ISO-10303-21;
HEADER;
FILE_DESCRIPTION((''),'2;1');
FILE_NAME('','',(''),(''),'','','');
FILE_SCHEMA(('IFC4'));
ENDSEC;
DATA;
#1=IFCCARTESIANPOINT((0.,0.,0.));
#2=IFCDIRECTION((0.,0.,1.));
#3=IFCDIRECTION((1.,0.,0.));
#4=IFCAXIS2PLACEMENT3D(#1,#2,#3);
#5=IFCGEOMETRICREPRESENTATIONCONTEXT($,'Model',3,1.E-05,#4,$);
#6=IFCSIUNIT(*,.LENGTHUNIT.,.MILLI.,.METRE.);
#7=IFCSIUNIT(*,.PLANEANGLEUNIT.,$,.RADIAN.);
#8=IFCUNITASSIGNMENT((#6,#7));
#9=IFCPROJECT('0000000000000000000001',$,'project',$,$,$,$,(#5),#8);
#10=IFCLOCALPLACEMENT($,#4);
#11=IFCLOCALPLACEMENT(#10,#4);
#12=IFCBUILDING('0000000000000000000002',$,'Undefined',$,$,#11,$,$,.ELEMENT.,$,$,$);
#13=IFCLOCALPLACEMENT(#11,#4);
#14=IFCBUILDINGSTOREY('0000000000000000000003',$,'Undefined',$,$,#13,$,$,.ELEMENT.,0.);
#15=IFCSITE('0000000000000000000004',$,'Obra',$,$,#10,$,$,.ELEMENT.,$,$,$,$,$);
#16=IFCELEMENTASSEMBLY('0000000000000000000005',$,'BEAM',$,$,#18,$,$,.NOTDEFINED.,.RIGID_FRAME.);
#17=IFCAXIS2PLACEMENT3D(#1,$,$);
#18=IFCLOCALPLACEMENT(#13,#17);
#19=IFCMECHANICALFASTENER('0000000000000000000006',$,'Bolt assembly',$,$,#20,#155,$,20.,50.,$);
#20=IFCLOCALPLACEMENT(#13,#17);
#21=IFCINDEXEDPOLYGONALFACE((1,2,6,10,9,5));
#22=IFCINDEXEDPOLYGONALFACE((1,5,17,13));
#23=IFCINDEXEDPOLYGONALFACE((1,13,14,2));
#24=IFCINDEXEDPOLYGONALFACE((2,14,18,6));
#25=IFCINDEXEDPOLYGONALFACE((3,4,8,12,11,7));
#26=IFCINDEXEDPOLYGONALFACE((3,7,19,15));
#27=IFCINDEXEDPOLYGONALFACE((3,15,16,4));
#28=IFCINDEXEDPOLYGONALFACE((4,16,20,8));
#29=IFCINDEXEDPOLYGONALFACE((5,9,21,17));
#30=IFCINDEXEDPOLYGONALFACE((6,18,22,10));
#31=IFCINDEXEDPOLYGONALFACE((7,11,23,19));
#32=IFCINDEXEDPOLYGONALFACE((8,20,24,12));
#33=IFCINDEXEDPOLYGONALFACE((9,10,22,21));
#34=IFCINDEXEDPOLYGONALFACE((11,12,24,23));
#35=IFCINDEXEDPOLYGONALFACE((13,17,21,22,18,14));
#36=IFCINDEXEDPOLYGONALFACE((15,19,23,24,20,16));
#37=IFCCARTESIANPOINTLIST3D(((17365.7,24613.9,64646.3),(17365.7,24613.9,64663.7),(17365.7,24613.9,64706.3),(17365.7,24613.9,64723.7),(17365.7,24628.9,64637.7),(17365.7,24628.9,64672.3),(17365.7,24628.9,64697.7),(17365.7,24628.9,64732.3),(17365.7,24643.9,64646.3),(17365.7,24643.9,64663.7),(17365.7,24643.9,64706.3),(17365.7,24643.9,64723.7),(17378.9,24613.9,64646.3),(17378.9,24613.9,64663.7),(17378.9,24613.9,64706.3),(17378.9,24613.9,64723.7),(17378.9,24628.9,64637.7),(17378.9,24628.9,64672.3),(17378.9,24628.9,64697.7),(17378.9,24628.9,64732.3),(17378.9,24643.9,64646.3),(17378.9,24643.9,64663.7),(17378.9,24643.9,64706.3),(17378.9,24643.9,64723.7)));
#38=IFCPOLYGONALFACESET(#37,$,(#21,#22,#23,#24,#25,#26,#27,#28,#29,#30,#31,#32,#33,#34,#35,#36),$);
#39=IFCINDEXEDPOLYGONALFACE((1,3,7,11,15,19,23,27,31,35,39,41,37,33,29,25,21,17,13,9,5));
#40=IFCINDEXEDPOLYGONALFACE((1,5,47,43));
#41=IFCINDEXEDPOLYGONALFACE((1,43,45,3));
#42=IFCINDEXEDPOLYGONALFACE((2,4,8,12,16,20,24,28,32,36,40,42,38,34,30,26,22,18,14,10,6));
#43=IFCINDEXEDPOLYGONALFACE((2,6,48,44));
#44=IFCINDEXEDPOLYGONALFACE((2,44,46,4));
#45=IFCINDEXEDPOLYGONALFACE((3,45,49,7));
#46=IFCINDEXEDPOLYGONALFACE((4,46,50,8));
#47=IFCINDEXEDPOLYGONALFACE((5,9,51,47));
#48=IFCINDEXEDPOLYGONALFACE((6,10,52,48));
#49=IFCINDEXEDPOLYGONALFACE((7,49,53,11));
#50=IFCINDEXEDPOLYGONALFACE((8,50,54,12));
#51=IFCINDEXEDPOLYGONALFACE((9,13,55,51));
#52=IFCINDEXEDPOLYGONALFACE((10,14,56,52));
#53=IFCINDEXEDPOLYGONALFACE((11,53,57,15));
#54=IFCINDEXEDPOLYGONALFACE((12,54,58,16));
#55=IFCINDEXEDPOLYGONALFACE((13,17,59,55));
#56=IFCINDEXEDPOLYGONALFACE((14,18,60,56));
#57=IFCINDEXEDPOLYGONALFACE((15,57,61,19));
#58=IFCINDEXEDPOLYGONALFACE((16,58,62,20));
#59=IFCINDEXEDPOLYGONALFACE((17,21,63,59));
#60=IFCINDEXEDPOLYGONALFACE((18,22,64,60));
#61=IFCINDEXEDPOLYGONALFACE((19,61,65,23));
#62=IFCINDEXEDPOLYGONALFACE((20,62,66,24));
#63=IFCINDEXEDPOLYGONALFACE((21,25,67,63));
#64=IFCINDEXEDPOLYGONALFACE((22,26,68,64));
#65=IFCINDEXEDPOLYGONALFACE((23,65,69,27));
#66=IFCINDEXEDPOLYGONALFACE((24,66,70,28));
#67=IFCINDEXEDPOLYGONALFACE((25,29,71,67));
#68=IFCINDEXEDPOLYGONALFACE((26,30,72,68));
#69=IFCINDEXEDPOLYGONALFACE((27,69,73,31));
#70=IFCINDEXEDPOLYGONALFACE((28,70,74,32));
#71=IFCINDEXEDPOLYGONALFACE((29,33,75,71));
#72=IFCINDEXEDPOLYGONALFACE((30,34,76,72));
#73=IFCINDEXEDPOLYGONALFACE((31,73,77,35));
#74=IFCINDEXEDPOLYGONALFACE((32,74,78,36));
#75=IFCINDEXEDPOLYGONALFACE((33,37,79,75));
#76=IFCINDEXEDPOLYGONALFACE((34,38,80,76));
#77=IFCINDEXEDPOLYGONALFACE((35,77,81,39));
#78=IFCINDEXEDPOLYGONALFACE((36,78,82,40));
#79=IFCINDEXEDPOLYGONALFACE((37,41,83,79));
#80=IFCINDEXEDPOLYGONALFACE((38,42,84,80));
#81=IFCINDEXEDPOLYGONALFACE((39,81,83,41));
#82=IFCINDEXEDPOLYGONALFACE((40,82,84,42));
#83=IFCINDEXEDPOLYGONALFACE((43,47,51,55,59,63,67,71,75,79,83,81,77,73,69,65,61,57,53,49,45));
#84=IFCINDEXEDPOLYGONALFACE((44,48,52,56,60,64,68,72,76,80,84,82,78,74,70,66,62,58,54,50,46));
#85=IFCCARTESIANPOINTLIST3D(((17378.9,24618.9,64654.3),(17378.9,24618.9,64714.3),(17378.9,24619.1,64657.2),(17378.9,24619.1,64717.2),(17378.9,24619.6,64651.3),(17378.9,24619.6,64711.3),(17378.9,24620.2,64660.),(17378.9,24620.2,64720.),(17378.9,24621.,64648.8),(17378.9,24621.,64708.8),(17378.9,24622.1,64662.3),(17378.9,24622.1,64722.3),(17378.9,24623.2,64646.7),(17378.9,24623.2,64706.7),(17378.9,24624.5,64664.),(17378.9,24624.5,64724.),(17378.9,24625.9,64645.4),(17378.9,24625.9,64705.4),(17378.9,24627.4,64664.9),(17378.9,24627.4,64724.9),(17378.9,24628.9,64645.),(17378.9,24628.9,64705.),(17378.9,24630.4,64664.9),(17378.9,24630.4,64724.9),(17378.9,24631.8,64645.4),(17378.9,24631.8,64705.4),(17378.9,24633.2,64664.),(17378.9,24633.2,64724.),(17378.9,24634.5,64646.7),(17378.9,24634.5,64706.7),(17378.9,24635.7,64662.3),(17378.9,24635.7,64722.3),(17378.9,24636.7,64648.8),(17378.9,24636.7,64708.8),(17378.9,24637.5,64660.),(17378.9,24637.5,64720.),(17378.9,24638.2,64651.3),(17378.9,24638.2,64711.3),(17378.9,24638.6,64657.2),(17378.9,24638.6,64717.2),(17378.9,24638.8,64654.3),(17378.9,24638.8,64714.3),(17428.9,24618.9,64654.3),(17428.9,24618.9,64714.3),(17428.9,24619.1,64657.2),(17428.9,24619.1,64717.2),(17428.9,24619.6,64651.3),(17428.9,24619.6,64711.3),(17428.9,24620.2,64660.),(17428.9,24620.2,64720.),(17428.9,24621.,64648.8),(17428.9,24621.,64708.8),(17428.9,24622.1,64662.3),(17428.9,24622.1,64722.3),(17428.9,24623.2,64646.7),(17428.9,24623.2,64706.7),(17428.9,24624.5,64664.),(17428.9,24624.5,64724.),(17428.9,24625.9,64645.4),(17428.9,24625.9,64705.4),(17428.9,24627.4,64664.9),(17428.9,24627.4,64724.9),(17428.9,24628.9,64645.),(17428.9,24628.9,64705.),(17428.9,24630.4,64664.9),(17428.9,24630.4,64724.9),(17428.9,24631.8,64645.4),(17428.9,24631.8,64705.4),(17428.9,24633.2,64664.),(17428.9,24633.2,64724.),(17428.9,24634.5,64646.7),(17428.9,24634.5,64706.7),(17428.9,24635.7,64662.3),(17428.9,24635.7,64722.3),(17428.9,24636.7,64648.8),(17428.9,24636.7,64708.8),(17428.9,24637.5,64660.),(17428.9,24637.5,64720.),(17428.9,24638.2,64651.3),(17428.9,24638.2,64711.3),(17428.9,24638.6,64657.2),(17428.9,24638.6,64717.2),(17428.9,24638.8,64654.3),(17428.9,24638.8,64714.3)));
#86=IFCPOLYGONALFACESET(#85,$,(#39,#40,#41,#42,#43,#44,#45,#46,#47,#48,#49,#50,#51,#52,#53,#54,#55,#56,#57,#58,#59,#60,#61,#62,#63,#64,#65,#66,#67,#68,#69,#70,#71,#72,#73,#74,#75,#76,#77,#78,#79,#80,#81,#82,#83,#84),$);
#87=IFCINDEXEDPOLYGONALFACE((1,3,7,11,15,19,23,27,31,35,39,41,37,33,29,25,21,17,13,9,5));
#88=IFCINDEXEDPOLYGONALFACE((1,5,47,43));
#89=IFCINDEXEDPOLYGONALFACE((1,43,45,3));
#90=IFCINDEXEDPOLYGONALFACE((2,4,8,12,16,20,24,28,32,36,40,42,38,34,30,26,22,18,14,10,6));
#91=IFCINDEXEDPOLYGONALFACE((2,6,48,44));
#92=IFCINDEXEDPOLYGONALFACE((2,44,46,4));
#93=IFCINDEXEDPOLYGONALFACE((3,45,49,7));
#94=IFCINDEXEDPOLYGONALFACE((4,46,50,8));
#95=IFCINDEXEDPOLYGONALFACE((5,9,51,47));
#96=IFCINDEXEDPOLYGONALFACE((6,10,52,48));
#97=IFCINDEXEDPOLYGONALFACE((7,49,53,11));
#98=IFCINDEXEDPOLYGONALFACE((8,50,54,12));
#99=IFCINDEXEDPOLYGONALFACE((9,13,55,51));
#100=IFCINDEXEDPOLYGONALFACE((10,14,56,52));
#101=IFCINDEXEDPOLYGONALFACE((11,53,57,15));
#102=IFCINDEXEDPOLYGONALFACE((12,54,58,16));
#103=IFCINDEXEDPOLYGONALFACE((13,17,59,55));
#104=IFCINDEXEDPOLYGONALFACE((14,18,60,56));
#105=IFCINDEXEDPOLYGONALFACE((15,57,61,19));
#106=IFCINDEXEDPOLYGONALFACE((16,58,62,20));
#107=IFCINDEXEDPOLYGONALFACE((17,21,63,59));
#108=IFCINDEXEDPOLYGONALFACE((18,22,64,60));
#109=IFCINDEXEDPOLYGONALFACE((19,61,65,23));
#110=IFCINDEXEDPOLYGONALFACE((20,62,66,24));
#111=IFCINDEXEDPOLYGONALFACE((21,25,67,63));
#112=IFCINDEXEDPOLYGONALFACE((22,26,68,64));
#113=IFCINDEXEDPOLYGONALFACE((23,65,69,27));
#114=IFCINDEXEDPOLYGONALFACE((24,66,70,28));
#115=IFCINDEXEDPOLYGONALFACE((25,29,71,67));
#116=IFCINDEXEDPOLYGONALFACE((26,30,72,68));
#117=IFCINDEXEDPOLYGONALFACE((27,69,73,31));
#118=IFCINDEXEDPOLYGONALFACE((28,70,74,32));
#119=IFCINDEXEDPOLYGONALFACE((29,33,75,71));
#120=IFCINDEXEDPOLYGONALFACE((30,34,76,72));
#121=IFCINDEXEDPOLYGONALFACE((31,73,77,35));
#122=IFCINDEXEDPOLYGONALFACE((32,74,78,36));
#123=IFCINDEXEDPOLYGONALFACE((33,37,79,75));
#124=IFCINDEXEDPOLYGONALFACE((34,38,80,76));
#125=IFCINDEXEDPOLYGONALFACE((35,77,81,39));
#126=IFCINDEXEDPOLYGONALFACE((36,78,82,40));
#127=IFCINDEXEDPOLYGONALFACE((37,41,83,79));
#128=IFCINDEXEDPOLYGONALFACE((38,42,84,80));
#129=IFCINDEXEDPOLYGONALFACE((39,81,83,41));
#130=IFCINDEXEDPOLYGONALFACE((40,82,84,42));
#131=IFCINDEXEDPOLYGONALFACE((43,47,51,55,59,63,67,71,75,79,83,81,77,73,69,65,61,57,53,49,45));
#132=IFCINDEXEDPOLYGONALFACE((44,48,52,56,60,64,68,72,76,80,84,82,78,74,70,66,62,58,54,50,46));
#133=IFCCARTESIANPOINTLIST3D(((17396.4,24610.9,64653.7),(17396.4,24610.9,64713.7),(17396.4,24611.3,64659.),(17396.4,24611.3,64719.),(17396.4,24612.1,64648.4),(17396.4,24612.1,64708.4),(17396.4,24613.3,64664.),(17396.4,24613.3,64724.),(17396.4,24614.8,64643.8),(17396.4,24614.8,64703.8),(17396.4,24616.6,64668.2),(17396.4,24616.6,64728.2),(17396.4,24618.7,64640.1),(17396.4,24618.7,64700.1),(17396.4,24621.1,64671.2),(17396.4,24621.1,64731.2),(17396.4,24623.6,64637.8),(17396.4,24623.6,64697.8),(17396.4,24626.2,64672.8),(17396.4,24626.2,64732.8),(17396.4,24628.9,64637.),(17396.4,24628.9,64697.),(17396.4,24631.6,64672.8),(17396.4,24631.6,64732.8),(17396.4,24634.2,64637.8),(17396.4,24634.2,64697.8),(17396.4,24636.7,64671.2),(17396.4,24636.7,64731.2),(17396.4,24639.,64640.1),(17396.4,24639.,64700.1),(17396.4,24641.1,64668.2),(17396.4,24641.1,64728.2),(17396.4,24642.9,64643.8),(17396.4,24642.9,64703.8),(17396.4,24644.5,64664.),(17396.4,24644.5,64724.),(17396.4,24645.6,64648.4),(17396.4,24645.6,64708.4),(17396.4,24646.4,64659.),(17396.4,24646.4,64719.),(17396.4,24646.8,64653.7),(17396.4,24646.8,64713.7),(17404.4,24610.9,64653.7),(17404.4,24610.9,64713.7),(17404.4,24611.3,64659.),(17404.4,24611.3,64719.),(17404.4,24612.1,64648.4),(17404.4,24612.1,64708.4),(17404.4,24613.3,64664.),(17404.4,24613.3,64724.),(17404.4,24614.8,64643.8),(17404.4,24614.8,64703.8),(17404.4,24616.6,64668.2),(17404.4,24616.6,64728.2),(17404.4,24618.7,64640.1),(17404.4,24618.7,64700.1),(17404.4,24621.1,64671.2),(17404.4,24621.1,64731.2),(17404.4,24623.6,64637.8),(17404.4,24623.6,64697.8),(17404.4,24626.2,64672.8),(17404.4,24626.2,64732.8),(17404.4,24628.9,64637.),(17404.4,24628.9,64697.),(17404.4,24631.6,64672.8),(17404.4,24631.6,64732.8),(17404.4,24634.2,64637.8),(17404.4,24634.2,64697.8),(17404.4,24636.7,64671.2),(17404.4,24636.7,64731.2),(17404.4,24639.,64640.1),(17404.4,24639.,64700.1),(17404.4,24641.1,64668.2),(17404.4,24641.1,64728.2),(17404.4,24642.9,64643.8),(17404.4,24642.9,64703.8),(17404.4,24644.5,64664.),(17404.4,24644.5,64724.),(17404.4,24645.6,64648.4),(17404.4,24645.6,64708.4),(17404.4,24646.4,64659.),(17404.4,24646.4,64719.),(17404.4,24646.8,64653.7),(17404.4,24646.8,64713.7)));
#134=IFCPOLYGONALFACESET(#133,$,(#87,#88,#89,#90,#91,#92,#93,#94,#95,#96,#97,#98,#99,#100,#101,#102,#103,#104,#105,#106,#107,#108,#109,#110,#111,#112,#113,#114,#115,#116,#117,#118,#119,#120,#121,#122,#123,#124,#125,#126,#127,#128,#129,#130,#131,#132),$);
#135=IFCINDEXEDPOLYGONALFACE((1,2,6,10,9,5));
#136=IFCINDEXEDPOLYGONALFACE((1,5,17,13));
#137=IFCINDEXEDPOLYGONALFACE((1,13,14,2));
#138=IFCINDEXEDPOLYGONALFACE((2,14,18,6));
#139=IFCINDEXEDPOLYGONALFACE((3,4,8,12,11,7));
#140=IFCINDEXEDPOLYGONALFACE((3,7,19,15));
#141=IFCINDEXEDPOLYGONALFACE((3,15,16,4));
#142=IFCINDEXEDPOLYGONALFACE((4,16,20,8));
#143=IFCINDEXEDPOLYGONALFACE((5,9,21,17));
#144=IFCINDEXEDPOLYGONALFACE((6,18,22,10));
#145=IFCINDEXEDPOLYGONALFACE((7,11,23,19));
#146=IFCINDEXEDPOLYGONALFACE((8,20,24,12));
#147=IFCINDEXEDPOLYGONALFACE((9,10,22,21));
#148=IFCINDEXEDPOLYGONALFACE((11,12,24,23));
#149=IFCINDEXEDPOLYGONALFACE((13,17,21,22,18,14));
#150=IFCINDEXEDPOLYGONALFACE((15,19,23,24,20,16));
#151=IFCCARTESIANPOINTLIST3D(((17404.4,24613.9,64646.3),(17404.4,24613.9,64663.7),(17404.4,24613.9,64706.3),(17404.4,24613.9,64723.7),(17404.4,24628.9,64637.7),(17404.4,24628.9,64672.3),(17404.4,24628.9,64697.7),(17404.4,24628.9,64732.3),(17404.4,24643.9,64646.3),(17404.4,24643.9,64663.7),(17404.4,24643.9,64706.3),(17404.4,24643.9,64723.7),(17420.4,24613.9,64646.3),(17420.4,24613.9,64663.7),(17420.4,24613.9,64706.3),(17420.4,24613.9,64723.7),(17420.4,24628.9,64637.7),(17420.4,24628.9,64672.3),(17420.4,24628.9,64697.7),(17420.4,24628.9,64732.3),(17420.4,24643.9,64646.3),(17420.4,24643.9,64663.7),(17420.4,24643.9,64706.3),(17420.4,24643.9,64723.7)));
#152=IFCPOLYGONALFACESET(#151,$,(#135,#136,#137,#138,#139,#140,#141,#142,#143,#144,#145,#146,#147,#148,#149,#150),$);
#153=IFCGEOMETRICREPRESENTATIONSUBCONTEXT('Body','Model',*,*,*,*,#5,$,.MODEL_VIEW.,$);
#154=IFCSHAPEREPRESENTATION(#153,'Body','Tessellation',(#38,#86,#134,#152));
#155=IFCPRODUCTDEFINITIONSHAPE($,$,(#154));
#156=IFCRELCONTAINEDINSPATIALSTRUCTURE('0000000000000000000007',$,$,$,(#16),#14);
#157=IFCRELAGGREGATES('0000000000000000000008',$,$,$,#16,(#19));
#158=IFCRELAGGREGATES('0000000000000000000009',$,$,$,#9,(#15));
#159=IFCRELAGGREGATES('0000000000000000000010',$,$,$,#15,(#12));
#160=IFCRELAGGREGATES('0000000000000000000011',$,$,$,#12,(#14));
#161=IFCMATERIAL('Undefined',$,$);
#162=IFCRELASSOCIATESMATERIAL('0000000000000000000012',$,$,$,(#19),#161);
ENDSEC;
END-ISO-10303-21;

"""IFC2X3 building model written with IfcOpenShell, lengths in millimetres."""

from ifc_helpers import new_model, si_unit, frame, origin_with_axes, origin_2d_with_axis, place, context, subcontext, project, spatial, polyline, circle, outline, extrude, source, transform, mapped, material, element, aggregate, save


model = new_model("IFC2X3")

# Units and contexts
model_context = context("Model", 3, precision=1e-05, world=origin_with_axes())
body_context = subcontext(model_context, "Body", "Model", "MODEL_VIEW")
ifc_project = project(units=[si_unit("LENGTHUNIT", "METRE", prefix="MILLI"), si_unit("PLANEANGLEUNIT", "RADIAN")], contexts=[model_context])

# Site, building, storey
site_placement = place(None, origin_with_axes())
site = spatial("IfcSite", under=ifc_project, at=site_placement, Name="Obra", CompositionType="ELEMENT")
building_placement = place(site_placement, origin_with_axes())
building = spatial("IfcBuilding", under=site, at=building_placement, Name="Undefined", CompositionType="ELEMENT")
storey_placement = place(building_placement, origin_with_axes())
storey = spatial("IfcBuildingStorey", under=building, at=storey_placement, Name="Undefined", CompositionType="ELEMENT", Elevation=0.0)

# Shared definitions
ifc_material = material(Name="Undefined")

# Element assembly
shared_shape_1 = source(origin_with_axes(), body_context, "Body", "SweptSolid", [
    extrude(outline(polyline([(17.3, 0.0), (8.7, 15.0), (-8.7, 15.0), (-17.3, 0.0), (-8.7, -15.0), (8.7, -15.0), (17.3, 0.0)])), frame((0.0, -27.0, 0.0), z_axis=(0.0, 1.0, 0.0), x_axis=(1.0, 0.0, 0.0)), (0.0, 0.0, 1.0), 13.2),
    extrude(circle(Radius=10.0, at=origin_2d_with_axis()), frame((0.0, -13.8, 0.0), z_axis=(0.0, 1.0, 0.0), x_axis=(1.0, 0.0, 0.0)), (0.0, 0.0, 1.0), 50.0),
    extrude(circle(Radius=18.0, at=origin_2d_with_axis()), frame((0.0, 3.7, 0.0), z_axis=(0.0, 1.0, 0.0), x_axis=(1.0, 0.0, 0.0)), (0.0, 0.0, 1.0), 8.0),
    extrude(outline(polyline([(17.3, 0.0), (8.7, 15.0), (-8.7, 15.0), (-17.3, 0.0), (-8.7, -15.0), (8.7, -15.0), (17.3, 0.0)])), frame((0.0, 11.7, 0.0), z_axis=(0.0, 1.0, 0.0), x_axis=(1.0, 0.0, 0.0)), (0.0, 0.0, 1.0), 16.0),
])
assembly_1_placement = place(storey_placement, origin_with_axes())
assembly_1 = element("IfcElementAssembly", 1, at=assembly_1_placement, inside=storey, Name="BEAM", AssemblyPlace="NOTDEFINED", PredefinedType="RIGID_FRAME")

# Mechanical fastener
mechanical_fastener_1_placement = place(assembly_1_placement, frame((17392.7, 24668.9, 64850.0), z_axis=(0.000002, -1.0, 0.0), x_axis=(0.0, 0.0, -1.0)))
mechanical_fastener_1 = element("IfcMechanicalFastener", 2, at=mechanical_fastener_1_placement, material=ifc_material, Name="Bolt assembly", NominalDiameter=20.0, NominalLength=50.0, context=body_context, shape_type="MappedRepresentation", body=[
    mapped(shared_shape_1, transform((135.0, 0.0, 40.0))),
    mapped(shared_shape_1, transform((195.0, 0.0, 40.0))),
])
aggregate(assembly_1, [mechanical_fastener_1])

save(model, "model.ifc")
